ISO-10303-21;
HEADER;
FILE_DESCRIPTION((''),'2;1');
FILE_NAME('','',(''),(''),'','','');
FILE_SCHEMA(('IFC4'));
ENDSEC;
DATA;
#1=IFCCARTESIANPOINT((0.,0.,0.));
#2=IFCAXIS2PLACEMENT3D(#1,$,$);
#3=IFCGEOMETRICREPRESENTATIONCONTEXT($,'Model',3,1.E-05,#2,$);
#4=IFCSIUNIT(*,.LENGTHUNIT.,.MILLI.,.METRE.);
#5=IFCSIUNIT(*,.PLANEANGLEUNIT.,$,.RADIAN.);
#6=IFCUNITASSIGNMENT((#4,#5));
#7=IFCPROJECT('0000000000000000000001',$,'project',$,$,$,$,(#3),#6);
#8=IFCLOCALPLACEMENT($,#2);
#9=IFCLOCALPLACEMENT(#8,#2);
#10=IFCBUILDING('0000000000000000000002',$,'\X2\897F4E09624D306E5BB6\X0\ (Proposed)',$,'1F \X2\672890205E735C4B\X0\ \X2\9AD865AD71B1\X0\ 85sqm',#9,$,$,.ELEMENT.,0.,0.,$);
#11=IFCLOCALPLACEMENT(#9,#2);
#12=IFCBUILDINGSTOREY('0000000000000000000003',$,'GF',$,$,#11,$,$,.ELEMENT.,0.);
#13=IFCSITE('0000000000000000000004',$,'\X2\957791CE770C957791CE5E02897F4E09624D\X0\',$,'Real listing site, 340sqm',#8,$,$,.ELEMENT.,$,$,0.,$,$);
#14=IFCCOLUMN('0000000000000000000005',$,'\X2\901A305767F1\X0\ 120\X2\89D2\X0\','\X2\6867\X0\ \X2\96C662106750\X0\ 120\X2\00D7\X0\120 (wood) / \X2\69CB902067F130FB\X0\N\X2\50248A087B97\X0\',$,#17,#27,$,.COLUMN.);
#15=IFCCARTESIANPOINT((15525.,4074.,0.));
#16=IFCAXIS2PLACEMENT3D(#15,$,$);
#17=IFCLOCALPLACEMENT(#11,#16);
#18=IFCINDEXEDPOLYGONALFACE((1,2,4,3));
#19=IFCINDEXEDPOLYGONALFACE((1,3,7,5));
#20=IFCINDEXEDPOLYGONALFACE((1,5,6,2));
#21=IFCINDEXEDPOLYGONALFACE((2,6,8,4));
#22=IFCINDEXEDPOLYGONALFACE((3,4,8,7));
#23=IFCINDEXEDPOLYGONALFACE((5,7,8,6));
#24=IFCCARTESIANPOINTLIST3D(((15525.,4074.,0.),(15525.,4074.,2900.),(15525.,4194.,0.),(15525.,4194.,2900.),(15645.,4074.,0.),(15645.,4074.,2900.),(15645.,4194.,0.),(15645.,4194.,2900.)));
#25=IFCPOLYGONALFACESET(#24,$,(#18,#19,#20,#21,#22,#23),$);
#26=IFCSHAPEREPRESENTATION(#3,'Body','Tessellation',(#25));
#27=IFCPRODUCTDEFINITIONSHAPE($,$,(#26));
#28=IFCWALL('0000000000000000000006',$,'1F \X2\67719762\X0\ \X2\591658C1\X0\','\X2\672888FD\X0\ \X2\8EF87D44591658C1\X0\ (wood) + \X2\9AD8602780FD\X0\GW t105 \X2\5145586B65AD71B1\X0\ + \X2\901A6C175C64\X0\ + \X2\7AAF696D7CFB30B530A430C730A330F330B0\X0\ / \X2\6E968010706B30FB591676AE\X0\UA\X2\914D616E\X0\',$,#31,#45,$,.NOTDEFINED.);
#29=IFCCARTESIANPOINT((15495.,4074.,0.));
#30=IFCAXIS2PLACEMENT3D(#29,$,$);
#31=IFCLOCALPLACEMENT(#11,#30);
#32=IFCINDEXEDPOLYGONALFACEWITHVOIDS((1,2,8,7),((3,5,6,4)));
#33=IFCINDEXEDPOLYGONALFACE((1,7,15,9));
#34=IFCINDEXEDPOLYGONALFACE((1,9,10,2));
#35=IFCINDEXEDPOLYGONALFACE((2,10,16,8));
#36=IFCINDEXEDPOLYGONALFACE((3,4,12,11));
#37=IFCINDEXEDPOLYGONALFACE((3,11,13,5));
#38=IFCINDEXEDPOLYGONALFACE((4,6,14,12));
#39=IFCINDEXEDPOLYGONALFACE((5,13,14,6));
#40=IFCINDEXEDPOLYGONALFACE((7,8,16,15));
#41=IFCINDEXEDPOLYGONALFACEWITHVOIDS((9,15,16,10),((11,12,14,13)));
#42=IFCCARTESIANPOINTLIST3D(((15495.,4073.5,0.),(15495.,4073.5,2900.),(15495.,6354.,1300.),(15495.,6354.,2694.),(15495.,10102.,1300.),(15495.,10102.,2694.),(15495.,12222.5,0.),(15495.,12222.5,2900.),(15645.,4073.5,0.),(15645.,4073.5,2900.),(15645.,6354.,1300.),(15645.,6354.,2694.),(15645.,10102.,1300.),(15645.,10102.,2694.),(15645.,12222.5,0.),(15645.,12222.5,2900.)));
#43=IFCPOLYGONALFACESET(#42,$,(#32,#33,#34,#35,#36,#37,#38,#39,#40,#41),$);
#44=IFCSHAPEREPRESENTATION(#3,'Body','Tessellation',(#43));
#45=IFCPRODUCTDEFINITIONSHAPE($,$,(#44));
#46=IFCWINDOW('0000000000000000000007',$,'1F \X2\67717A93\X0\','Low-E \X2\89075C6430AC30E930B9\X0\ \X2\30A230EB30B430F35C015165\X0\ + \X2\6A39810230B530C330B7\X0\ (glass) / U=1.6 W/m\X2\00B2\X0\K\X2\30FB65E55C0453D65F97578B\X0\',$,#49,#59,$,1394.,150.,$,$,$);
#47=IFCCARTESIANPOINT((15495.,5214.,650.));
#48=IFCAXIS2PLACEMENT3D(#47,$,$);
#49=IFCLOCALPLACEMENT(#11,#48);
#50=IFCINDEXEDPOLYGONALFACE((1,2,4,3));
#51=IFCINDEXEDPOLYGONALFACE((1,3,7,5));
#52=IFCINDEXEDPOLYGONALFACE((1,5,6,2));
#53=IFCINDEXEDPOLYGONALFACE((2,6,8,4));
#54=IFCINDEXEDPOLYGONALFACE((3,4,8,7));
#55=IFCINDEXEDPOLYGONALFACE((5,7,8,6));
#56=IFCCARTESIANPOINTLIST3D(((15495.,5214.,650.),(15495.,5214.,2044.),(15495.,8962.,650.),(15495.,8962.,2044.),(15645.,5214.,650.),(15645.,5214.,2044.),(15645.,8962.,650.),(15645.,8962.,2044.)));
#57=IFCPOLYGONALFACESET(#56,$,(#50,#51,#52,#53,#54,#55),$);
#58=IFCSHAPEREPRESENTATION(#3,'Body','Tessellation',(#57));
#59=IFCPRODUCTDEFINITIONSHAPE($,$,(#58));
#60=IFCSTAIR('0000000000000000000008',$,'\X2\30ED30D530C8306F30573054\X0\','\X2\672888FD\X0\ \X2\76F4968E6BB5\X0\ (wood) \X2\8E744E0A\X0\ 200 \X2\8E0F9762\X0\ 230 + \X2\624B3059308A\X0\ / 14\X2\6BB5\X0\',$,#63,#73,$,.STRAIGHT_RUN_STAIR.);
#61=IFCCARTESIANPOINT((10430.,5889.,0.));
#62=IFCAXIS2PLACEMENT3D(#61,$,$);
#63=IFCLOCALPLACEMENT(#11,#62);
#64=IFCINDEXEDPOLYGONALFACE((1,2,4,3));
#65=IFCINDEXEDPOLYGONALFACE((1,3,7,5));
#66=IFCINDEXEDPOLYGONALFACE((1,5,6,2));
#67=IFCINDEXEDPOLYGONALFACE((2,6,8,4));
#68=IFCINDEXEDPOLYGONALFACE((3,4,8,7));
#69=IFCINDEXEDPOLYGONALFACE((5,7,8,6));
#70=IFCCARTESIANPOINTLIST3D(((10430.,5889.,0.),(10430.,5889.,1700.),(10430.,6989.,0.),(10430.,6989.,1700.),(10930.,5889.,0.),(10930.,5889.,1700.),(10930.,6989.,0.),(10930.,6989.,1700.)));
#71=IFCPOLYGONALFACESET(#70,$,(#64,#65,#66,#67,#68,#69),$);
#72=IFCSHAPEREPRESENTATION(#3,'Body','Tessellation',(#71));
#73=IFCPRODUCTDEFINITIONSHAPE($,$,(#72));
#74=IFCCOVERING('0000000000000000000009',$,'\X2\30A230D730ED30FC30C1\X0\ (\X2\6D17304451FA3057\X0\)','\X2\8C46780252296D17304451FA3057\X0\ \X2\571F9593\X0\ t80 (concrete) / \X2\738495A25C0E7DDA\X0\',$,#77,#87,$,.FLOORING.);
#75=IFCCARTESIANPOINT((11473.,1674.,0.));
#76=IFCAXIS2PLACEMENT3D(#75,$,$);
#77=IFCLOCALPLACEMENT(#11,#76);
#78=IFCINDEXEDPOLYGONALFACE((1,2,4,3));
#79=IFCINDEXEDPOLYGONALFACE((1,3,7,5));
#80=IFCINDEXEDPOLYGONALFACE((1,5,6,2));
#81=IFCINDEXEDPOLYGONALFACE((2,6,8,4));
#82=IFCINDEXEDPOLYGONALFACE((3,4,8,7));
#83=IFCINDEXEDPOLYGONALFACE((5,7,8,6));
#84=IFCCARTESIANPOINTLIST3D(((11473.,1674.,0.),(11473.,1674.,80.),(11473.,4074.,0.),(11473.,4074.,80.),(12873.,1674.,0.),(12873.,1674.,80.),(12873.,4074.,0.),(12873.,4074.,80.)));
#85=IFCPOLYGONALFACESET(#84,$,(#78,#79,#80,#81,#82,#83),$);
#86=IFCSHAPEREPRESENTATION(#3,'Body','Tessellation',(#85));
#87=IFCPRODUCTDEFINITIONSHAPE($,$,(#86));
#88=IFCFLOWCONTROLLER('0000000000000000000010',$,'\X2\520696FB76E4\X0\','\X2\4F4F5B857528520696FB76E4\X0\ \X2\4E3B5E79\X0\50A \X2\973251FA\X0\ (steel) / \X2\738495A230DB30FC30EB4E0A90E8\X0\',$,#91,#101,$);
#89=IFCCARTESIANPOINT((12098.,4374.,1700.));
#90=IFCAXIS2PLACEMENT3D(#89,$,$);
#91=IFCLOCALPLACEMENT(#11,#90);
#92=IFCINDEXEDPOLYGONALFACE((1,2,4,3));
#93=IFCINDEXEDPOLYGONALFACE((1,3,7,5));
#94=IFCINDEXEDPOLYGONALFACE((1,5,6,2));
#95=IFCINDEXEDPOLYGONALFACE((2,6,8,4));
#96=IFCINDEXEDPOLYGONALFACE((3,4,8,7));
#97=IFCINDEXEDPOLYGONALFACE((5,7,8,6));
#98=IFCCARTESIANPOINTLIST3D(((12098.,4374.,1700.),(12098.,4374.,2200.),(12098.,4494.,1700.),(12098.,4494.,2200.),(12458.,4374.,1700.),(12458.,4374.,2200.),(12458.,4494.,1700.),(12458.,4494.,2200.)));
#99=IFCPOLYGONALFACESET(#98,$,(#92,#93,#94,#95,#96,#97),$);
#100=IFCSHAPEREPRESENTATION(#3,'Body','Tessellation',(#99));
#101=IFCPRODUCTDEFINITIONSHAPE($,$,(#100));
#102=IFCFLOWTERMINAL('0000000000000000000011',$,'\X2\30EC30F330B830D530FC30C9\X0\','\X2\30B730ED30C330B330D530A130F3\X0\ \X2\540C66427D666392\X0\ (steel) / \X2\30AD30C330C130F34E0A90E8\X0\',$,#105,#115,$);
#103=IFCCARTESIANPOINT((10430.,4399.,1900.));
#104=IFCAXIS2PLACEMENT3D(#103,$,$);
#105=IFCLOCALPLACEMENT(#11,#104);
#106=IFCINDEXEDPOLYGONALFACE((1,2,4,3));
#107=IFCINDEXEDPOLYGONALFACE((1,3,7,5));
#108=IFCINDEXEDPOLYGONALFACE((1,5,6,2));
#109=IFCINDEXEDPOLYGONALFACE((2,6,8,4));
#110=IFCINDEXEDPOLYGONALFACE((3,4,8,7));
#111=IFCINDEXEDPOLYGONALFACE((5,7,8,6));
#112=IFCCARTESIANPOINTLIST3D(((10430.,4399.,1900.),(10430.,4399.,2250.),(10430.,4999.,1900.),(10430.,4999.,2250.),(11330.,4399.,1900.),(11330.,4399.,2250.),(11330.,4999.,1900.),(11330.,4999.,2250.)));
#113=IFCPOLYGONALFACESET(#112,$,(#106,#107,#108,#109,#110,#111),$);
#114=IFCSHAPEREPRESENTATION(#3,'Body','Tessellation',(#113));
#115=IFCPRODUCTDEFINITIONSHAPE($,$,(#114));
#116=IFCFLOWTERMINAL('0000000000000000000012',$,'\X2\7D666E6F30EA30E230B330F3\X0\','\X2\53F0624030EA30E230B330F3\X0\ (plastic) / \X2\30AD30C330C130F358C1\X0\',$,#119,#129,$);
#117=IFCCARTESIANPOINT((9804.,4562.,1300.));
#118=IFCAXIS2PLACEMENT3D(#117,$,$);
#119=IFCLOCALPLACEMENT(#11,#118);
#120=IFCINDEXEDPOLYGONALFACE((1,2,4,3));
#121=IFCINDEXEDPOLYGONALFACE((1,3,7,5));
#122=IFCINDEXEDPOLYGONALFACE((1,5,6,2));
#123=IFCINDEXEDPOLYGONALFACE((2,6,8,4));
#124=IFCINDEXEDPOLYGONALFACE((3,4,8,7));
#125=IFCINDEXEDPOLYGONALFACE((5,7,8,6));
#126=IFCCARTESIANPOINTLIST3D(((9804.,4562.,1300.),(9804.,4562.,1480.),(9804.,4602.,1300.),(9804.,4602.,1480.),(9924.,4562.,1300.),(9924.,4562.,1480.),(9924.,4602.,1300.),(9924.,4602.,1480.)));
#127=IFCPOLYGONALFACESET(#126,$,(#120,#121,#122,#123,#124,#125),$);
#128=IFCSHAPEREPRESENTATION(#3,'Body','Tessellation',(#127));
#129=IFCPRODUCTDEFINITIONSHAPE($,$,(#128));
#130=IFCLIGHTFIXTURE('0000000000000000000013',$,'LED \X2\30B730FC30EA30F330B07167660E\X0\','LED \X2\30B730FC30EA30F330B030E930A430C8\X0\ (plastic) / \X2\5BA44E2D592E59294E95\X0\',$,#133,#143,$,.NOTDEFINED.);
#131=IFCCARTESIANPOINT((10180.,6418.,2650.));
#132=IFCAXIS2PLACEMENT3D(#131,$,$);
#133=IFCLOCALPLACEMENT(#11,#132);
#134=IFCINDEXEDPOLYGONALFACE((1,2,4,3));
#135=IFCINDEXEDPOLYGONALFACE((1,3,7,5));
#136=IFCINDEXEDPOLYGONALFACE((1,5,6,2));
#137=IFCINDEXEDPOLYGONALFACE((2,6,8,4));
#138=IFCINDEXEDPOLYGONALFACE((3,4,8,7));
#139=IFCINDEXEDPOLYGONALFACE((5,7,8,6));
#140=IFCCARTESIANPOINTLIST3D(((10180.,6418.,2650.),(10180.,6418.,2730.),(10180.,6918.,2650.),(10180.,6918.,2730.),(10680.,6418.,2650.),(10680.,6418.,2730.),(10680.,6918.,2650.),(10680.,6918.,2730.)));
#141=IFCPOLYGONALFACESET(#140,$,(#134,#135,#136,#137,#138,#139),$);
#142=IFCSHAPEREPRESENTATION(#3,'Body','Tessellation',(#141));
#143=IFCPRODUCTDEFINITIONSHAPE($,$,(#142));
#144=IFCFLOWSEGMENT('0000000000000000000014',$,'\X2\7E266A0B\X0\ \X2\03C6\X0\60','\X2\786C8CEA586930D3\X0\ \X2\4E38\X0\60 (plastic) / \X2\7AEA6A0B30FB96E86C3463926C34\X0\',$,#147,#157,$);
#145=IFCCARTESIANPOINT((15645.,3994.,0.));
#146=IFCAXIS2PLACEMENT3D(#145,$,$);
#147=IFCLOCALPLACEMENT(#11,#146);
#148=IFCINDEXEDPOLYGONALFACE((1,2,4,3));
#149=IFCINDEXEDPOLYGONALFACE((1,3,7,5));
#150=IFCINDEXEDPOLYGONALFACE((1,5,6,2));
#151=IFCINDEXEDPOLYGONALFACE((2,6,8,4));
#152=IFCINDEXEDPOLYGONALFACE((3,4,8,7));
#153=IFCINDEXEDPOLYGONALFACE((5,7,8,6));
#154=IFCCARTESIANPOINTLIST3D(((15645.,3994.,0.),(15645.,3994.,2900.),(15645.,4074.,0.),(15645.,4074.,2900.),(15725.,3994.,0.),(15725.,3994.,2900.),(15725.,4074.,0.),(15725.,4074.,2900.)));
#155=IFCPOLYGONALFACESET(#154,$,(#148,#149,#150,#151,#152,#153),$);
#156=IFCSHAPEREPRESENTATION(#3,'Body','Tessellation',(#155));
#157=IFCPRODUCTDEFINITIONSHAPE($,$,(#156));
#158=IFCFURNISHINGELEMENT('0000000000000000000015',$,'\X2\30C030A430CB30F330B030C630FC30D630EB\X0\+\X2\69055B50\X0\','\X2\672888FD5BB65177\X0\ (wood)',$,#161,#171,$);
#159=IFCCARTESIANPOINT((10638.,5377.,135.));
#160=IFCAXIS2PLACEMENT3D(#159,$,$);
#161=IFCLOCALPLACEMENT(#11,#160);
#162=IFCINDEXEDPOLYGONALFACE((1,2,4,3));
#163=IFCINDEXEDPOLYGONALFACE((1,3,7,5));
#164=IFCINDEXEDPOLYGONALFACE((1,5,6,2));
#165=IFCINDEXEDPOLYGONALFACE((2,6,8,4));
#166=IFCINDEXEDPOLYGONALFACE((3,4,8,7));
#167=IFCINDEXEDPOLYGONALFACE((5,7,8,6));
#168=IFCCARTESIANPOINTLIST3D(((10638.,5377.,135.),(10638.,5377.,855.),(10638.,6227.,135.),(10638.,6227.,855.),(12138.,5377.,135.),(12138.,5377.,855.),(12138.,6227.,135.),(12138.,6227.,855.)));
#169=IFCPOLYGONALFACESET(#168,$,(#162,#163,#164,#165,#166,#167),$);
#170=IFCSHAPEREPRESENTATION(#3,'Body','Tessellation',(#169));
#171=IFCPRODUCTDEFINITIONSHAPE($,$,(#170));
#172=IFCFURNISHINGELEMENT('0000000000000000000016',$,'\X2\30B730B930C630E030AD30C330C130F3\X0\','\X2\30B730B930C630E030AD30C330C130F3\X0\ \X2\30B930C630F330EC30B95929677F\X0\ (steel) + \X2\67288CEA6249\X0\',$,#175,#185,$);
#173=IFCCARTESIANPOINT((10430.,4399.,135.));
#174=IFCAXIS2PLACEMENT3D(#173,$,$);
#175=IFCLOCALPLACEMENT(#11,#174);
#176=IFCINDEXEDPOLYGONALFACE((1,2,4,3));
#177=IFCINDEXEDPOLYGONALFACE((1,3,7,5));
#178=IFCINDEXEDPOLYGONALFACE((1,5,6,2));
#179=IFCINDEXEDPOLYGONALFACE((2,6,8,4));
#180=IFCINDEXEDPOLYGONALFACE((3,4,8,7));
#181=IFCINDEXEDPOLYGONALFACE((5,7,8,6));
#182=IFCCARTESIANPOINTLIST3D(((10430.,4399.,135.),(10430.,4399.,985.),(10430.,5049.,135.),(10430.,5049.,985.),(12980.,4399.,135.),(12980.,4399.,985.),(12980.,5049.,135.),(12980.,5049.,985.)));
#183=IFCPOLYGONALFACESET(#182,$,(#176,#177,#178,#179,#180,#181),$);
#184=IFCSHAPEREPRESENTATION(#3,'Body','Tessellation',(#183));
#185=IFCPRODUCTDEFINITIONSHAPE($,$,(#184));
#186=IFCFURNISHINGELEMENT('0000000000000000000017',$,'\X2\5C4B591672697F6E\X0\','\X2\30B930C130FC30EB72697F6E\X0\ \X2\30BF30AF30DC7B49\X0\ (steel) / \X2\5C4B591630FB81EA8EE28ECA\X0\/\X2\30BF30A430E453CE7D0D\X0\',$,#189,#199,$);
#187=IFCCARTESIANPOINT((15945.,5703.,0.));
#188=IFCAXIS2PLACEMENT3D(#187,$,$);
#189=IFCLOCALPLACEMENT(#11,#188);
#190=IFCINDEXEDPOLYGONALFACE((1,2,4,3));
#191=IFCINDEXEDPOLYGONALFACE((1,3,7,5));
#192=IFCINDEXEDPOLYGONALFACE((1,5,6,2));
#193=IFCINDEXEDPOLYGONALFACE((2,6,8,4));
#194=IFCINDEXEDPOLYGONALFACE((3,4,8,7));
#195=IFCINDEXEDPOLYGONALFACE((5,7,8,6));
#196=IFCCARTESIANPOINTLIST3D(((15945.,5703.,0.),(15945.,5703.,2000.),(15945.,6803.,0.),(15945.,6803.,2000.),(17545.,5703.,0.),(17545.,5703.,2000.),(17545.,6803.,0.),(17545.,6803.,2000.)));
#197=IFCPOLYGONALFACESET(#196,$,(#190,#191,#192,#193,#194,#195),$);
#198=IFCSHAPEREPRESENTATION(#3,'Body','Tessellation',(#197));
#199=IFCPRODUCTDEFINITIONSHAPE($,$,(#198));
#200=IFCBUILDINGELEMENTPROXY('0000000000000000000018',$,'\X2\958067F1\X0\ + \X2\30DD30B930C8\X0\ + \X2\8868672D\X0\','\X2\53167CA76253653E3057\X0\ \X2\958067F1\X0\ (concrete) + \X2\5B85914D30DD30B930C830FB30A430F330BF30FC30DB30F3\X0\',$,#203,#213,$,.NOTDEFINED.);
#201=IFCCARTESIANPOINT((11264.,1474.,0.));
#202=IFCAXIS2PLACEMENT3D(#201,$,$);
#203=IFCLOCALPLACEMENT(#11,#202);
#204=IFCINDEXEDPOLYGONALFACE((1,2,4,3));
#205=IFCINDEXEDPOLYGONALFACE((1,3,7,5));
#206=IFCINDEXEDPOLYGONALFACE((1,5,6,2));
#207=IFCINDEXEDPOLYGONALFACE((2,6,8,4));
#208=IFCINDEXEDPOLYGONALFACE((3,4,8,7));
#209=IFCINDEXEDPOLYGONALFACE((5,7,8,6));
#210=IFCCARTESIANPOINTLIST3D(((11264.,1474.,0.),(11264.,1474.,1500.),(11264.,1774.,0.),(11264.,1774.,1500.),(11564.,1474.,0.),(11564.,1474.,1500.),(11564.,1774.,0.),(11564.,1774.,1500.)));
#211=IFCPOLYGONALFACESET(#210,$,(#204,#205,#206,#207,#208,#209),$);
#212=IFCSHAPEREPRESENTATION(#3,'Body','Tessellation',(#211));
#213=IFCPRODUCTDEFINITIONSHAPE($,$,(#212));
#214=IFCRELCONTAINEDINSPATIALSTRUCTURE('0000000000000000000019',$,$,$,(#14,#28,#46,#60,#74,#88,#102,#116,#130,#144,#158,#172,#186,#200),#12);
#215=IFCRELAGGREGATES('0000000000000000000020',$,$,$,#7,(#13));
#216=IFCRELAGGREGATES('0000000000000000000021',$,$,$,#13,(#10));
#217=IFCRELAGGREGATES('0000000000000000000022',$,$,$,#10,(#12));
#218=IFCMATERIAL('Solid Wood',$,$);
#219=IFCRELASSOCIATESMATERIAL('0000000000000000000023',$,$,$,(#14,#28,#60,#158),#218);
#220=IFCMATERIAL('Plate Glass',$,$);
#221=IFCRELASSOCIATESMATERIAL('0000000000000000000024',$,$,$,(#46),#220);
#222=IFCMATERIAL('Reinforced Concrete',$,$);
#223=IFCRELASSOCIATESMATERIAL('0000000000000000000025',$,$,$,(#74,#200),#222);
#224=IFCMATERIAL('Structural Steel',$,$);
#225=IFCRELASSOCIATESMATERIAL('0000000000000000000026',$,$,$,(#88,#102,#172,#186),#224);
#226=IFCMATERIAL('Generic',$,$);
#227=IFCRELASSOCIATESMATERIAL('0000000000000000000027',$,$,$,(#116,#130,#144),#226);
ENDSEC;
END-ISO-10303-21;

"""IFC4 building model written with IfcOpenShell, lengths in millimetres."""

from ifc_helpers import new_model, si_unit, frame, frame_2d, origin, place, context, project, spatial, rectangle, extrude, material, element, fill, save


model = new_model("IFC4")

# Units and contexts
model_context = context("Model", 3, precision=1e-05, world=origin())
ifc_project = project(units=[si_unit("LENGTHUNIT", "METRE", prefix="MILLI"), si_unit("PLANEANGLEUNIT", "RADIAN")], contexts=[model_context])

# Site, building, storey
site_placement = place(None, origin())
site = spatial("IfcSite", under=ifc_project, at=site_placement, Name="長野県長野市西三才", ObjectType="Real listing site, 340sqm", CompositionType="ELEMENT", RefElevation=0.0)
building_placement = place(site_placement, origin())
building = spatial("IfcBuilding", under=site, at=building_placement, Name="西三才の家 (Proposed)", ObjectType="1F 木造平屋 高断熱 85sqm", CompositionType="ELEMENT", ElevationOfRefHeight=0.0, ElevationOfTerrain=0.0)
storey_placement = place(building_placement, origin())
storey = spatial("IfcBuildingStorey", under=building, at=storey_placement, Name="GF", CompositionType="ELEMENT", Elevation=0.0)

# Column
ifc_material_1 = material(Name="Solid Wood")
column_1_placement = place(storey_placement, frame((15525.0, 4074.0, 0.0)))
element("IfcColumn", 1, at=column_1_placement, inside=storey, material=ifc_material_1, Name="通し柱 120角", Description="桧 集成材 120×120 (wood) / 構造柱・N値計算", PredefinedType="COLUMN", context=model_context, shape_type="SweptSolid", body=[
    extrude(rectangle(XDim=120.0, YDim=120.0, at=frame_2d((60.0, 60.0))), frame((15525.0, 4074.0, 0.0)), (0.0, 0.0, 1.0), 2900.0),
])

# Wall, opening, window
wall_1_placement = place(storey_placement, frame((15495.0, 4074.0, 0.0)))
wall_1 = element("IfcWall", 2, at=wall_1_placement, inside=storey, material=ifc_material_1, Name="1F 東面 外壁", Description="木製 軸組外壁 (wood) + 高性能GW t105 充填断熱 + 通気層 + 窯業系サイディング / 準耐火・外皮UA配慮", PredefinedType="NOTDEFINED", context=model_context, shape_type="SweptSolid", body=[
    extrude(rectangle(XDim=150.0, YDim=8149.0, at=frame_2d((75.0, 4074.0))), frame((15495.0, 4074.0, 0.0)), (0.0, 0.0, 1.0), 2900.0),
])
opening_placement = place(storey_placement, frame((15495.0, 5214.0, 650.0)))
opening = element("IfcOpeningElement", 3, at=opening_placement, cuts=wall_1, PredefinedType="NOTDEFINED", context=model_context, shape_type="SweptSolid", body=[
    extrude(rectangle(XDim=150.0, YDim=3748.0, at=frame_2d((75.0, 1874.0))), frame((15495.0, 5214.0, 650.0)), (0.0, 0.0, 1.0), 1394.0),
])
ifc_material_2 = material(Name="Plate Glass")
window_placement = place(storey_placement, frame((15495.0, 5214.0, 650.0)))
window = element("IfcWindow", 4, at=window_placement, inside=storey, material=ifc_material_2, Name="1F 東窓", Description="Low-E 複層ガラス アルゴン封入 + 樹脂サッシ (glass) / U=1.6 W/m²K・日射取得型", OverallHeight=1394.0, OverallWidth=150.0, context=model_context, shape_type="SweptSolid", body=[
    extrude(rectangle(XDim=150.0, YDim=3748.0, at=frame_2d((75.0, 1874.0))), frame((15495.0, 5214.0, 650.0)), (0.0, 0.0, 1.0), 1394.0),
])
fill(opening, window)

# Stair
stair_placement = place(storey_placement, frame((10430.0, 5889.0, 0.0)))
element("IfcStair", 5, at=stair_placement, inside=storey, material=ifc_material_1, Name="ロフトはしご", Description="木製 直階段 (wood) 蹴上 200 踏面 230 + 手すり / 14段", PredefinedType="STRAIGHT_RUN_STAIR", context=model_context, shape_type="SweptSolid", body=[
    extrude(rectangle(XDim=500.0, YDim=1100.0, at=frame_2d((250.0, 550.0))), frame((10430.0, 5889.0, 0.0)), (0.0, 0.0, 1.0), 1700.0),
])

# Covering
ifc_material_3 = material(Name="Reinforced Concrete")
covering_placement = place(storey_placement, frame((11473.0, 1674.0, 0.0)))
element("IfcCovering", 6, at=covering_placement, inside=storey, material=ifc_material_3, Name="アプローチ (洗い出し)", Description="豆砂利洗い出し 土間 t80 (concrete) / 玄関導線", PredefinedType="FLOORING", context=model_context, shape_type="SweptSolid", body=[
    extrude(rectangle(XDim=1400.0, YDim=2400.0, at=frame_2d((700.0, 1200.0))), frame((11473.0, 1674.0, 0.0)), (0.0, 0.0, 1.0), 80.0),
])

# Flow controller
ifc_material_4 = material(Name="Structural Steel")
flow_controller_placement = place(storey_placement, frame((12098.0, 4374.0, 1700.0)))
element("IfcFlowController", 7, at=flow_controller_placement, inside=storey, material=ifc_material_4, Name="分電盤", Description="住宅用分電盤 主幹50A 露出 (steel) / 玄関ホール上部", context=model_context, shape_type="SweptSolid", body=[
    extrude(rectangle(XDim=360.0, YDim=120.0, at=frame_2d((180.0, 60.0))), frame((12098.0, 4374.0, 1700.0)), (0.0, 0.0, 1.0), 500.0),
])

# Flow terminals
flow_terminal_1_placement = place(storey_placement, frame((10430.0, 4399.0, 1900.0)))
element("IfcFlowTerminal", 8, at=flow_terminal_1_placement, inside=storey, material=ifc_material_4, Name="レンジフード", Description="シロッコファン 同時給排 (steel) / キッチン上部", context=model_context, shape_type="SweptSolid", body=[
    extrude(rectangle(XDim=900.0, YDim=600.0, at=frame_2d((450.0, 300.0))), frame((10430.0, 4399.0, 1900.0)), (0.0, 0.0, 1.0), 350.0),
])
ifc_material_5 = material(Name="Generic")
flow_terminal_2_placement = place(storey_placement, frame((9804.0, 4562.0, 1300.0)))
element("IfcFlowTerminal", 9, at=flow_terminal_2_placement, inside=storey, material=ifc_material_5, Name="給湯リモコン", Description="台所リモコン (plastic) / キッチン壁", context=model_context, shape_type="SweptSolid", body=[
    extrude(rectangle(XDim=120.0, YDim=40.0, at=frame_2d((60.0, 20.0))), frame((9804.0, 4562.0, 1300.0)), (0.0, 0.0, 1.0), 180.0),
])

# Light fixture
light_fixture_placement = place(storey_placement, frame((10180.0, 6418.0, 2650.0)))
element("IfcLightFixture", 10, at=light_fixture_placement, inside=storey, material=ifc_material_5, Name="LED シーリング照明", Description="LED シーリングライト (plastic) / 室中央天井", PredefinedType="NOTDEFINED", context=model_context, shape_type="SweptSolid", body=[
    extrude(rectangle(XDim=500.0, YDim=500.0, at=frame_2d((250.0, 250.0))), frame((10180.0, 6418.0, 2650.0)), (0.0, 0.0, 1.0), 80.0),
])

# Flow segment
flow_segment_placement = place(storey_placement, frame((15645.0, 3994.0, 0.0)))
element("IfcFlowSegment", 11, at=flow_segment_placement, inside=storey, material=ifc_material_5, Name="縦樋 φ60", Description="硬質塩ビ 丸60 (plastic) / 竪樋・雨水排水", context=model_context, shape_type="SweptSolid", body=[
    extrude(rectangle(XDim=80.0, YDim=80.0, at=frame_2d((40.0, 40.0))), frame((15645.0, 3994.0, 0.0)), (0.0, 0.0, 1.0), 2900.0),
])

# Furnishing elements
furnishing_1_placement = place(storey_placement, frame((10638.0, 5377.0, 135.0)))
element("IfcFurnishingElement", 12, at=furnishing_1_placement, inside=storey, material=ifc_material_1, Name="ダイニングテーブル+椅子", Description="木製家具 (wood)", context=model_context, shape_type="SweptSolid", body=[
    extrude(rectangle(XDim=1500.0, YDim=850.0, at=frame_2d((750.0, 425.0))), frame((10638.0, 5377.0, 135.0)), (0.0, 0.0, 1.0), 720.0),
])
furnishing_2_placement = place(storey_placement, frame((10430.0, 4399.0, 135.0)))
element("IfcFurnishingElement", 13, at=furnishing_2_placement, inside=storey, material=ifc_material_4, Name="システムキッチン", Description="システムキッチン ステンレス天板 (steel) + 木質扉", context=model_context, shape_type="SweptSolid", body=[
    extrude(rectangle(XDim=2550.0, YDim=650.0, at=frame_2d((1275.0, 325.0))), frame((10430.0, 4399.0, 135.0)), (0.0, 0.0, 1.0), 850.0),
])
furnishing_3_placement = place(storey_placement, frame((15945.0, 5703.0, 0.0)))
element("IfcFurnishingElement", 14, at=furnishing_3_placement, inside=storey, material=ifc_material_4, Name="屋外物置", Description="スチール物置 タクボ等 (steel) / 屋外・自転車/タイヤ収納", context=model_context, shape_type="SweptSolid", body=[
    extrude(rectangle(XDim=1600.0, YDim=1100.0, at=frame_2d((800.0, 550.0))), frame((15945.0, 5703.0, 0.0)), (0.0, 0.0, 1.0), 2000.0),
])

# Building element proxy
proxy_placement = place(storey_placement, frame((11264.0, 1474.0, 0.0)))
element("IfcBuildingElementProxy", 15, at=proxy_placement, inside=storey, material=ifc_material_3, Name="門柱 + ポスト + 表札", Description="化粧打放し 門柱 (concrete) + 宅配ポスト・インターホン", PredefinedType="NOTDEFINED", context=model_context, shape_type="SweptSolid", body=[
    extrude(rectangle(XDim=300.0, YDim=300.0, at=frame_2d((150.0, 150.0))), frame((11264.0, 1474.0, 0.0)), (0.0, 0.0, 1.0), 1500.0),
])

save(model, "model.ifc")
